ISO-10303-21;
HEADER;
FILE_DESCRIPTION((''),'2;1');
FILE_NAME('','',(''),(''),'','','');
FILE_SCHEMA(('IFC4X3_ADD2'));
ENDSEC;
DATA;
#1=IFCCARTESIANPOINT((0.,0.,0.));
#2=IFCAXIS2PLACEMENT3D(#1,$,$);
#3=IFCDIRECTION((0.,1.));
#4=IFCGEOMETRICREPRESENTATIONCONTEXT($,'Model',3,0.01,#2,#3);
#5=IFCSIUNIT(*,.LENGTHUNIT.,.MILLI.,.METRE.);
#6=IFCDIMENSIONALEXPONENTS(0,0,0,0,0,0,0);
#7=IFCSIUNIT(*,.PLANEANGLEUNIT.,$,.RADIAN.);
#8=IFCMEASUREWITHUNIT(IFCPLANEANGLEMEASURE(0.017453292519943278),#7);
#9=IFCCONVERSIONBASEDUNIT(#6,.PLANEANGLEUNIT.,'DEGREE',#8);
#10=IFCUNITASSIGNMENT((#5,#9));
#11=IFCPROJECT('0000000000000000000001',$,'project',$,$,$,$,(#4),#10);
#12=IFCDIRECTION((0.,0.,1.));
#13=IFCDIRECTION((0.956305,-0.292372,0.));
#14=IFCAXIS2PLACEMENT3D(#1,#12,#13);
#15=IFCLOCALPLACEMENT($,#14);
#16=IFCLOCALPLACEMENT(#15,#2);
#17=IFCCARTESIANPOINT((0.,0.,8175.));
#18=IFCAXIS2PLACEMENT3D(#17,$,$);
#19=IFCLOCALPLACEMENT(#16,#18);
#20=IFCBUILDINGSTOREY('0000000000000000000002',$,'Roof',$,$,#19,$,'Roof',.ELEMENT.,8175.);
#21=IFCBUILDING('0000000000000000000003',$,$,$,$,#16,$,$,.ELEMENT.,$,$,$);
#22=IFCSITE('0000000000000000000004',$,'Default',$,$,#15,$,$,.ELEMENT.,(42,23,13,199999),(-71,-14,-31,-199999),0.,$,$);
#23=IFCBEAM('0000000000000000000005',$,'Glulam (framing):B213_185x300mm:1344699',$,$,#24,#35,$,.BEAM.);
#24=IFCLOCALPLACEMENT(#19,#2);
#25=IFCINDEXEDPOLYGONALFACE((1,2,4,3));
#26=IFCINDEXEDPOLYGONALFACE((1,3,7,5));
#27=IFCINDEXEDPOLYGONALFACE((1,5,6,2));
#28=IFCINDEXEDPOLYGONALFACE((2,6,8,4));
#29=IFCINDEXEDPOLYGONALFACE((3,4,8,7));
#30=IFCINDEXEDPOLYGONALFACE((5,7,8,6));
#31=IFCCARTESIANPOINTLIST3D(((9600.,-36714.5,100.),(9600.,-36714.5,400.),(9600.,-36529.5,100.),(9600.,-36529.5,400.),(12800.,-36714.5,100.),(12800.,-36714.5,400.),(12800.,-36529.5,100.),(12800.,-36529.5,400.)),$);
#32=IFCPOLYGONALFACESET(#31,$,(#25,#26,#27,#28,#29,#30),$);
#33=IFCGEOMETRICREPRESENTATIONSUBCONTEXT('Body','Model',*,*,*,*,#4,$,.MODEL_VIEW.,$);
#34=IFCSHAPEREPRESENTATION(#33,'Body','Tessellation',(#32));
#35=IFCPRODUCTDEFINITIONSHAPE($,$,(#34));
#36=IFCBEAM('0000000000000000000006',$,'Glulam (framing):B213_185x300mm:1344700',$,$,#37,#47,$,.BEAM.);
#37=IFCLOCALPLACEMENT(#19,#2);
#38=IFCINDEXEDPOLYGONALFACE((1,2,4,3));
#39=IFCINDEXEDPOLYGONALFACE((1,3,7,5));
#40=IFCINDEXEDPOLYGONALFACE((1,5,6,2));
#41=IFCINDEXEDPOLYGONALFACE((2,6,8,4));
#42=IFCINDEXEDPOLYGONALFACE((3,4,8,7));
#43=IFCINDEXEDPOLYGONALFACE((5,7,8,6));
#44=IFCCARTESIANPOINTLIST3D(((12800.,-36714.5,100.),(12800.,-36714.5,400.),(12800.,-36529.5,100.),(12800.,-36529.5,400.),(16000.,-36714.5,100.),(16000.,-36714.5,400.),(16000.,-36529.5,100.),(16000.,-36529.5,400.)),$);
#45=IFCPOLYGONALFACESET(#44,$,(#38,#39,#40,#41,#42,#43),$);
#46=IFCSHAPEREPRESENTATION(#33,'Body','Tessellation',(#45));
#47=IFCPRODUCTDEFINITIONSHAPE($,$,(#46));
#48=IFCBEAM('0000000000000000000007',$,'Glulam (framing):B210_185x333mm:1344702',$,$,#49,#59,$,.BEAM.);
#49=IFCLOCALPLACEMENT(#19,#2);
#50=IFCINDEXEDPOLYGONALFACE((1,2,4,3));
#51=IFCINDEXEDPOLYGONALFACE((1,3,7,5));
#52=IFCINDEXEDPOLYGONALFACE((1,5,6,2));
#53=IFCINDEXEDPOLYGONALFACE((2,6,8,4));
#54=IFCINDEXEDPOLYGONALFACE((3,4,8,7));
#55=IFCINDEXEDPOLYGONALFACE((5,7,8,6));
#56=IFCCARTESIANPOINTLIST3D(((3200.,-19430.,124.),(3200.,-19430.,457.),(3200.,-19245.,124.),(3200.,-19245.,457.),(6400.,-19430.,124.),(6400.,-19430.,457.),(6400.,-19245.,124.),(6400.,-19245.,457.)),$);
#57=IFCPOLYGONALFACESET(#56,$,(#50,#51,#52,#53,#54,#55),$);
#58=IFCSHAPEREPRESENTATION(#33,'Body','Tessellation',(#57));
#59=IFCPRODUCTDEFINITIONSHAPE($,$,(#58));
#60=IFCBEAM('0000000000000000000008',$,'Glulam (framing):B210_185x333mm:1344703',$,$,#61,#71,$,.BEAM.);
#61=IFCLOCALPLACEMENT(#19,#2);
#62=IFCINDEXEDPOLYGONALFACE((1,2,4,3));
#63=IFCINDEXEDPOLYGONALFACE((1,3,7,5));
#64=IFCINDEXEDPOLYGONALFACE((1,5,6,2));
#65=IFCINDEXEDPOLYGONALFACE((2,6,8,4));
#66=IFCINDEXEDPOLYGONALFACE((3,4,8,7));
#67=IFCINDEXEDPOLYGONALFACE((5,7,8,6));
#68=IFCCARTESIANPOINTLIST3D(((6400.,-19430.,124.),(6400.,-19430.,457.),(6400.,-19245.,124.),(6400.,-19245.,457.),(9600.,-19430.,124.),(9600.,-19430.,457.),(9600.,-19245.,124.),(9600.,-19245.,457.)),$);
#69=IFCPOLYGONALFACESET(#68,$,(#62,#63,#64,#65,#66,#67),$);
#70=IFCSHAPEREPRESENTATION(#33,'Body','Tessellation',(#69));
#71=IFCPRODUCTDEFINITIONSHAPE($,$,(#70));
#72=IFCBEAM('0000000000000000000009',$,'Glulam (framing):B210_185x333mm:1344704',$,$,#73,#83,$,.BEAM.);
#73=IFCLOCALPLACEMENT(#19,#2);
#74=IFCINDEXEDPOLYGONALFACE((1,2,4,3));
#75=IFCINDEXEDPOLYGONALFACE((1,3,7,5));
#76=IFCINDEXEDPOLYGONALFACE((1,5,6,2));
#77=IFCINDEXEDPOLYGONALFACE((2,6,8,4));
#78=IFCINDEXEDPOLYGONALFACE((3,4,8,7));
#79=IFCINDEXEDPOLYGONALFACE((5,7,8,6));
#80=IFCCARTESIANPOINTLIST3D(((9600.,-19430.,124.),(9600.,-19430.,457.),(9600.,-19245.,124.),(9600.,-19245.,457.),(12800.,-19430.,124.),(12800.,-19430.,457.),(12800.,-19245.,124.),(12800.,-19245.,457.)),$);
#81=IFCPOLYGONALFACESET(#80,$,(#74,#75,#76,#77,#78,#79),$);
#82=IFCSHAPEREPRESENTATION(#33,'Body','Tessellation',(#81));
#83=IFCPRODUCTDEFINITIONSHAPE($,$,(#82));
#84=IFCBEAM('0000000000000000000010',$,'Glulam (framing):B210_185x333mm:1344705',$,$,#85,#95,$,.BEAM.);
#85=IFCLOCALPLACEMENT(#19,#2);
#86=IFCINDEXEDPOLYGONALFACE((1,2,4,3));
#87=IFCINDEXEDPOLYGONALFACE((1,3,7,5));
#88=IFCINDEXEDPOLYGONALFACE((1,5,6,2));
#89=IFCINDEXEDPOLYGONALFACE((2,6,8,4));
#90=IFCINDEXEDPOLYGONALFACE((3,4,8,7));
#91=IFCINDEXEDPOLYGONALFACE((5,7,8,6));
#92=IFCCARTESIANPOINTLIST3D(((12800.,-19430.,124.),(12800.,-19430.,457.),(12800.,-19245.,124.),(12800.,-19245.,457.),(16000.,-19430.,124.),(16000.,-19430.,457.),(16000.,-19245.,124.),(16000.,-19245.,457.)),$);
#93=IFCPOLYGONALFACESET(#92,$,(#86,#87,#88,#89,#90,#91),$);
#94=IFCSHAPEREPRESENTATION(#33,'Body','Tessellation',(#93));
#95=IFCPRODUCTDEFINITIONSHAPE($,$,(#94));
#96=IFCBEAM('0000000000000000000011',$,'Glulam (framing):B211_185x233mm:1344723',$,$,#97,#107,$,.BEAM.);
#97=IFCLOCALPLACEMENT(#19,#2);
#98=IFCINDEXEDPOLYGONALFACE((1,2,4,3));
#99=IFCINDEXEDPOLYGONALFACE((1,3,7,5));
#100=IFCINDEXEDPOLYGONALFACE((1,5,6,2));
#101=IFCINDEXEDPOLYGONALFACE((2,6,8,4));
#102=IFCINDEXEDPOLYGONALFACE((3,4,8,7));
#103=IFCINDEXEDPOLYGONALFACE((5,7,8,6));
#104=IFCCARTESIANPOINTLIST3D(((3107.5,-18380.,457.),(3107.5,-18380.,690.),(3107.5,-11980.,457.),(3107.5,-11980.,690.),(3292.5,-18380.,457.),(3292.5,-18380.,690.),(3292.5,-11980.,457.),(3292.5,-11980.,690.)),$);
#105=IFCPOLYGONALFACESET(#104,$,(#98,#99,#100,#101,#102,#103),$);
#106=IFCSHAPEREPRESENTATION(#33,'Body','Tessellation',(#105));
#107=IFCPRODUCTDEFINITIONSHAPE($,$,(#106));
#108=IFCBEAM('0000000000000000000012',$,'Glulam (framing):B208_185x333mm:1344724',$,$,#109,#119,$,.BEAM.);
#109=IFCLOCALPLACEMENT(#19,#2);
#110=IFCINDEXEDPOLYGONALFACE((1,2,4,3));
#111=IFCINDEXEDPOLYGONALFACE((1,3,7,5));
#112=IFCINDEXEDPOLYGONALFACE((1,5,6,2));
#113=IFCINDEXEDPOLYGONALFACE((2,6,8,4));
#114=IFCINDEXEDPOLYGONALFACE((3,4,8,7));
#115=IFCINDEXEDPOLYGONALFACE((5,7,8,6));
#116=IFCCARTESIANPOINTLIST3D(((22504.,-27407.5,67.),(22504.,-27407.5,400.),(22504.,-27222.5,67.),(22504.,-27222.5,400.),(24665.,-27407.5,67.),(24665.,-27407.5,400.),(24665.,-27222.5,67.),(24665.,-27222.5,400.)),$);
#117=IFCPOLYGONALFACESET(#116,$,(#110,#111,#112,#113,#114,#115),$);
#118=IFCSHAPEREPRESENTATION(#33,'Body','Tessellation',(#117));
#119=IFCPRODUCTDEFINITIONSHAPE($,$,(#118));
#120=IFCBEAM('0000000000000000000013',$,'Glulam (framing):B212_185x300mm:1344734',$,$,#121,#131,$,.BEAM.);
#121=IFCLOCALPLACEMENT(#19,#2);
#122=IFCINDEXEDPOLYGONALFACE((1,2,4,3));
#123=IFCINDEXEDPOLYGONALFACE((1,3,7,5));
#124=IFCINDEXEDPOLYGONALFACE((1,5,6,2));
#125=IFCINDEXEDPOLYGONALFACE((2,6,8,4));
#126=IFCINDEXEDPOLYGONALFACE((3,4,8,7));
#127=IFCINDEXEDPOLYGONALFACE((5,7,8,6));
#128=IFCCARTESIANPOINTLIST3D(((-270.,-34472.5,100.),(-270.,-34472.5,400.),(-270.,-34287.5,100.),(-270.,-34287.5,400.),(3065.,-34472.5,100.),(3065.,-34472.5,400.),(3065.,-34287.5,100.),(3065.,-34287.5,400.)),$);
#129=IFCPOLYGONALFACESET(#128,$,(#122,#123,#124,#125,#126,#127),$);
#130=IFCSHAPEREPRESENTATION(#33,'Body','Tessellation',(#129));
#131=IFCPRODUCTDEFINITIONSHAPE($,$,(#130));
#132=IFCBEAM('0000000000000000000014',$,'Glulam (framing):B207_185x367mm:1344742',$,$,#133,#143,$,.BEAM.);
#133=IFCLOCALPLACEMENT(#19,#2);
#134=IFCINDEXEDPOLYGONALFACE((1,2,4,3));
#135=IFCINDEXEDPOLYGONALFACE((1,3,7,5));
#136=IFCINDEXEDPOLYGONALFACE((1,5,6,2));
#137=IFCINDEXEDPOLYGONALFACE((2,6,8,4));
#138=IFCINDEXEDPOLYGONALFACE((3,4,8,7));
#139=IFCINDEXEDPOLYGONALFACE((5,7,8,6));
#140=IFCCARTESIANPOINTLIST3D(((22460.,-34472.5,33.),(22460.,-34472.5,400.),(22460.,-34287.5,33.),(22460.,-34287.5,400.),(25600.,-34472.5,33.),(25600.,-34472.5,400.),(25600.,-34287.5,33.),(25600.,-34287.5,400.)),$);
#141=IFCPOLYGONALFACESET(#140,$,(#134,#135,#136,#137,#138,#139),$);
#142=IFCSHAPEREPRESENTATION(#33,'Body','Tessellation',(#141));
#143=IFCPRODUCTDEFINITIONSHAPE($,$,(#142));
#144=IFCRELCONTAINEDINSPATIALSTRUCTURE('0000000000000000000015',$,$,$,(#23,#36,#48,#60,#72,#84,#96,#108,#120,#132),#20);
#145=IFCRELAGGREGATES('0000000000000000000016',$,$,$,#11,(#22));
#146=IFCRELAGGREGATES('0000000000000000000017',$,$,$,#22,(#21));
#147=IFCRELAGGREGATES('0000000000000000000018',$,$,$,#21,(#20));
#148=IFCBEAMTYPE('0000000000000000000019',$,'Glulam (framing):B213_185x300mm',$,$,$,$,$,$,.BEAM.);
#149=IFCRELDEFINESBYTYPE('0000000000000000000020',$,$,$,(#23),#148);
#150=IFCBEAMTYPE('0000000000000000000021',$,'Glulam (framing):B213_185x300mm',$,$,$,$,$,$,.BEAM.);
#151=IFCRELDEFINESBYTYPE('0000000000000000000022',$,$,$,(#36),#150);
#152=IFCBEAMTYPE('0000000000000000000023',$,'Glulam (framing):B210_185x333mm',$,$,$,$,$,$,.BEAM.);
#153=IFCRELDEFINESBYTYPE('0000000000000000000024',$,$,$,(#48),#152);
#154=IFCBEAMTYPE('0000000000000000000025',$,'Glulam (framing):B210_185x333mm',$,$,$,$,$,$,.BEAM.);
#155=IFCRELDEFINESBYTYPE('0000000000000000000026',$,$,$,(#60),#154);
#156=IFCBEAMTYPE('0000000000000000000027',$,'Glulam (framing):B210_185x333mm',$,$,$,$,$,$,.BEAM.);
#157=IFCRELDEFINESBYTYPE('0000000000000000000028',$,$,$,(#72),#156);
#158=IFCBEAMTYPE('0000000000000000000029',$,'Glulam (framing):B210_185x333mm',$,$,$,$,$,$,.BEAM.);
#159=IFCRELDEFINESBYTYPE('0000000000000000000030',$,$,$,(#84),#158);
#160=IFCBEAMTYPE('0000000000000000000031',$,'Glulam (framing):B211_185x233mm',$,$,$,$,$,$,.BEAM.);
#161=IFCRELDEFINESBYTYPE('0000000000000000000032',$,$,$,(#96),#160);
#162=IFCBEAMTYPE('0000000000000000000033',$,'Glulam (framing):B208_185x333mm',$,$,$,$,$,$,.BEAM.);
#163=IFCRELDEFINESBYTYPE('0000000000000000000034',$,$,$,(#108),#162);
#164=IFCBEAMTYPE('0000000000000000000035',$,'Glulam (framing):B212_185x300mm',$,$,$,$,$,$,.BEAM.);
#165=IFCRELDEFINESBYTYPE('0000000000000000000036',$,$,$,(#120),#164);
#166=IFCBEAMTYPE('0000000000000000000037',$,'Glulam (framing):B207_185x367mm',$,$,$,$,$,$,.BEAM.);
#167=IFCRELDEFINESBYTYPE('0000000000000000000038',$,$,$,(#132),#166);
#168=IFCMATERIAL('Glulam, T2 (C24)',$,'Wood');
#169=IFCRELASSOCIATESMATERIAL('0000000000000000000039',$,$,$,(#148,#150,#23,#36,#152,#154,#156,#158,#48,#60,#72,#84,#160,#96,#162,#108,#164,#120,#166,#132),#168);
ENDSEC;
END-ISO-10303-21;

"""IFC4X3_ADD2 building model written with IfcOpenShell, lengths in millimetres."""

from ifc_helpers import new_model, entity, si_unit, converted_unit, direction, frame, origin, origin_2d_with_axis, place, context, subcontext, project, spatial, rectangle, extrude, source, transform, mapped, material, material_profile, profile_set, profile_usage, type_object, type_shapes, element, save


model = new_model("IFC4X3_ADD2")

# Units and contexts
model_context = context("Model", 3, precision=0.01, world=origin(), true_north=direction((0.0, 1.0)))
body_context = subcontext(model_context, "Body", "Model", "MODEL_VIEW")
ifc_project = project(units=[si_unit("LENGTHUNIT", "METRE", prefix="MILLI"), converted_unit("PLANEANGLEUNIT", "DEGREE", entity("IfcPlaneAngleMeasure", 0.017453292519943278), si_unit("PLANEANGLEUNIT", "RADIAN"), dimensions=[0, 0, 0, 0, 0, 0, 0])], contexts=[model_context])

# Site, building, storey
site_placement = place(None, frame((0.0, 0.0, 0.0), z_axis=(0.0, 0.0, 1.0), x_axis=(0.956305, -0.292372, 0.0)))
site = spatial("IfcSite", under=ifc_project, at=site_placement, Name="Default", CompositionType="ELEMENT", RefLatitude=(42, 23, 13, 199999), RefLongitude=(-71, -14, -31, -199999), RefElevation=0.0)
building_placement = place(site_placement, origin())
building = spatial("IfcBuilding", under=site, at=building_placement, CompositionType="ELEMENT")
storey_placement = place(building_placement, frame((0.0, 0.0, 8175.0)))
storey = spatial("IfcBuildingStorey", under=building, at=storey_placement, Name="Roof", LongName="Roof", CompositionType="ELEMENT", Elevation=8175.0)

# Beams
ifc_material = material(Name="Glulam, T2 (C24)", Category="Wood")
ifc_material_profile_1 = material_profile(ifc_material, rectangle(XDim=3200.0, YDim=185.0, at=origin_2d_with_axis()), Name="B213_185x300mm")
ifc_profile_set_1 = profile_set([ifc_material_profile_1], Name="B213_185x300mm")
ifc_profile_usage_1 = profile_usage(ifc_profile_set_1, cardinal=8)
beam_type_1 = type_object("IfcBeamType", Name="Glulam (framing):B213_185x300mm", PredefinedType="BEAM", material=ifc_profile_set_1)
shared_shape_1 = source(origin(), body_context, "Body", "SweptSolid", [
    extrude(rectangle(XDim=3200.0, YDim=185.0, at=origin_2d_with_axis()), frame((0.0, 0.0, -150.0), z_axis=(0.0, 0.0, 1.0), x_axis=(-1.0, 0.0, 0.0)), (0.0, 0.0, 1.0), 300.0),
])
type_shapes(beam_type_1, [shared_shape_1])
beam_1_placement = place(storey_placement, frame((11200.0, -36622.0, 250.0), z_axis=(0.0, 0.0, 1.0), x_axis=(-1.0, 0.0, 0.0)))
element("IfcBeam", 1, at=beam_1_placement, inside=storey, type_object=beam_type_1, material=ifc_profile_usage_1, Name="Glulam (framing):B213_185x300mm:1344699", PredefinedType="BEAM", context=body_context, shape_type="MappedRepresentation", body=[
    mapped(shared_shape_1, transform((0.0, 0.0, 0.0), scale=1.0)),
])
beam_type_2 = type_object("IfcBeamType", Name="Glulam (framing):B213_185x300mm", PredefinedType="BEAM", material=ifc_profile_set_1)
shared_shape_2 = source(origin(), body_context, "Body", "SweptSolid", [
    extrude(rectangle(XDim=3200.0, YDim=185.0, at=origin_2d_with_axis()), frame((0.0, 0.0, -150.0), z_axis=(0.0, 0.0, 1.0), x_axis=(-1.0, 0.0, 0.0)), (0.0, 0.0, 1.0), 300.0),
])
type_shapes(beam_type_2, [shared_shape_2])
beam_2_placement = place(storey_placement, frame((14400.0, -36622.0, 250.0), z_axis=(0.0, 0.0, 1.0), x_axis=(-1.0, 0.0, 0.0)))
element("IfcBeam", 2, at=beam_2_placement, inside=storey, type_object=beam_type_2, material=ifc_profile_usage_1, Name="Glulam (framing):B213_185x300mm:1344700", PredefinedType="BEAM", context=body_context, shape_type="MappedRepresentation", body=[
    mapped(shared_shape_2, transform((0.0, 0.0, 0.0), scale=1.0)),
])
ifc_material_profile_2 = material_profile(ifc_material, rectangle(XDim=185.0, YDim=3200.0, at=origin_2d_with_axis()), Name="B210_185x333mm")
ifc_profile_set_2 = profile_set([ifc_material_profile_2], Name="B210_185x333mm")
ifc_profile_usage_2 = profile_usage(ifc_profile_set_2, cardinal=8)
beam_type_3 = type_object("IfcBeamType", Name="Glulam (framing):B210_185x333mm", PredefinedType="BEAM", material=ifc_profile_set_2)
shared_shape_3 = source(origin(), body_context, "Body", "SweptSolid", [
    extrude(rectangle(XDim=185.0, YDim=3200.0, at=origin_2d_with_axis()), frame((0.0, 0.0, -166.5), z_axis=(0.0, 0.0, 1.0), x_axis=(0.0, 1.0, 0.0)), (0.0, 0.0, 1.0), 333.0),
])
type_shapes(beam_type_3, [shared_shape_3])
beam_3_placement = place(storey_placement, frame((4800.0, -19337.5, 290.5), z_axis=(0.0, 0.0, 1.0), x_axis=(-1.0, 0.0, 0.0)))
element("IfcBeam", 3, at=beam_3_placement, inside=storey, type_object=beam_type_3, material=ifc_profile_usage_2, Name="Glulam (framing):B210_185x333mm:1344702", PredefinedType="BEAM", context=body_context, shape_type="MappedRepresentation", body=[
    mapped(shared_shape_3, transform((0.0, 0.0, 0.0), scale=1.0)),
])
beam_type_4 = type_object("IfcBeamType", Name="Glulam (framing):B210_185x333mm", PredefinedType="BEAM", material=ifc_profile_set_2)
shared_shape_4 = source(origin(), body_context, "Body", "SweptSolid", [
    extrude(rectangle(XDim=185.0, YDim=3200.0, at=origin_2d_with_axis()), frame((0.0, 0.0, -166.5), z_axis=(0.0, 0.0, 1.0), x_axis=(0.0, 1.0, 0.0)), (0.0, 0.0, 1.0), 333.0),
])
type_shapes(beam_type_4, [shared_shape_4])
beam_4_placement = place(storey_placement, frame((8000.0, -19337.5, 290.5), z_axis=(0.0, 0.0, 1.0), x_axis=(-1.0, 0.0, 0.0)))
element("IfcBeam", 4, at=beam_4_placement, inside=storey, type_object=beam_type_4, material=ifc_profile_usage_2, Name="Glulam (framing):B210_185x333mm:1344703", PredefinedType="BEAM", context=body_context, shape_type="MappedRepresentation", body=[
    mapped(shared_shape_4, transform((0.0, 0.0, 0.0), scale=1.0)),
])
beam_type_5 = type_object("IfcBeamType", Name="Glulam (framing):B210_185x333mm", PredefinedType="BEAM", material=ifc_profile_set_2)
shared_shape_5 = source(origin(), body_context, "Body", "SweptSolid", [
    extrude(rectangle(XDim=185.0, YDim=3200.0, at=origin_2d_with_axis()), frame((0.0, 0.0, -166.5), z_axis=(0.0, 0.0, 1.0), x_axis=(0.0, 1.0, 0.0)), (0.0, 0.0, 1.0), 333.0),
])
type_shapes(beam_type_5, [shared_shape_5])
beam_5_placement = place(storey_placement, frame((11200.0, -19337.5, 290.5), z_axis=(0.0, 0.0, 1.0), x_axis=(-1.0, 0.0, 0.0)))
element("IfcBeam", 5, at=beam_5_placement, inside=storey, type_object=beam_type_5, material=ifc_profile_usage_2, Name="Glulam (framing):B210_185x333mm:1344704", PredefinedType="BEAM", context=body_context, shape_type="MappedRepresentation", body=[
    mapped(shared_shape_5, transform((0.0, 0.0, 0.0), scale=1.0)),
])
beam_type_6 = type_object("IfcBeamType", Name="Glulam (framing):B210_185x333mm", PredefinedType="BEAM", material=ifc_profile_set_2)
shared_shape_6 = source(origin(), body_context, "Body", "SweptSolid", [
    extrude(rectangle(XDim=185.0, YDim=3200.0, at=origin_2d_with_axis()), frame((0.0, 0.0, -166.5), z_axis=(0.0, 0.0, 1.0), x_axis=(0.0, 1.0, 0.0)), (0.0, 0.0, 1.0), 333.0),
])
type_shapes(beam_type_6, [shared_shape_6])
beam_6_placement = place(storey_placement, frame((14400.0, -19337.5, 290.5), z_axis=(0.0, 0.0, 1.0), x_axis=(-1.0, 0.0, 0.0)))
element("IfcBeam", 6, at=beam_6_placement, inside=storey, type_object=beam_type_6, material=ifc_profile_usage_2, Name="Glulam (framing):B210_185x333mm:1344705", PredefinedType="BEAM", context=body_context, shape_type="MappedRepresentation", body=[
    mapped(shared_shape_6, transform((0.0, 0.0, 0.0), scale=1.0)),
])
ifc_material_profile_3 = material_profile(ifc_material, rectangle(XDim=3200.0, YDim=185.0, at=origin_2d_with_axis()), Name="B211_185x233mm")
ifc_profile_set_3 = profile_set([ifc_material_profile_3], Name="B211_185x233mm")
ifc_profile_usage_3 = profile_usage(ifc_profile_set_3, cardinal=8)
beam_type_7 = type_object("IfcBeamType", Name="Glulam (framing):B211_185x233mm", PredefinedType="BEAM", material=ifc_profile_set_3)
shared_shape_7 = source(origin(), body_context, "Body", "SweptSolid", [
    extrude(rectangle(XDim=6400.0, YDim=185.0, at=origin_2d_with_axis()), frame((-1600.0, 0.0, -116.5), z_axis=(0.0, 0.0, 1.0), x_axis=(-1.0, 0.0, 0.0)), (0.0, 0.0, 1.0), 233.0),
])
type_shapes(beam_type_7, [shared_shape_7])
beam_7_placement = place(storey_placement, frame((3200.0, -16780.0, 573.5), z_axis=(0.0, 0.0, 1.0), x_axis=(0.0, -1.0, 0.0)))
element("IfcBeam", 7, at=beam_7_placement, inside=storey, type_object=beam_type_7, material=ifc_profile_usage_3, Name="Glulam (framing):B211_185x233mm:1344723", PredefinedType="BEAM", context=body_context, shape_type="MappedRepresentation", body=[
    mapped(shared_shape_7, transform((0.0, 0.0, 0.0), scale=1.0)),
])
ifc_material_profile_4 = material_profile(ifc_material, rectangle(XDim=2161.0, YDim=185.0, at=origin_2d_with_axis()), Name="B208_185x333mm")
ifc_profile_set_4 = profile_set([ifc_material_profile_4], Name="B208_185x333mm")
ifc_profile_usage_4 = profile_usage(ifc_profile_set_4, cardinal=8)
beam_type_8 = type_object("IfcBeamType", Name="Glulam (framing):B208_185x333mm", PredefinedType="BEAM", material=ifc_profile_set_4)
shared_shape_8 = source(origin(), body_context, "Body", "SweptSolid", [
    extrude(rectangle(XDim=2161.0, YDim=185.0, at=origin_2d_with_axis()), frame((-505.4, 0.0, -166.5), z_axis=(0.0, 0.0, 1.0), x_axis=(-1.0, 0.0, 0.0)), (0.0, 0.0, 1.0), 333.0),
])
type_shapes(beam_type_8, [shared_shape_8])
beam_8_placement = place(storey_placement, frame((24089.9, -27315.0, 233.5)))
element("IfcBeam", 8, at=beam_8_placement, inside=storey, type_object=beam_type_8, material=ifc_profile_usage_4, Name="Glulam (framing):B208_185x333mm:1344724", PredefinedType="BEAM", context=body_context, shape_type="MappedRepresentation", body=[
    mapped(shared_shape_8, transform((0.0, 0.0, 0.0), scale=1.0)),
])
ifc_material_profile_5 = material_profile(ifc_material, rectangle(XDim=3335.0, YDim=185.0, at=origin_2d_with_axis()), Name="B212_185x300mm")
ifc_profile_set_5 = profile_set([ifc_material_profile_5], Name="B212_185x300mm")
ifc_profile_usage_5 = profile_usage(ifc_profile_set_5, cardinal=8)
beam_type_9 = type_object("IfcBeamType", Name="Glulam (framing):B212_185x300mm", PredefinedType="BEAM", material=ifc_profile_set_5)
shared_shape_9 = source(origin(), body_context, "Body", "SweptSolid", [
    extrude(rectangle(XDim=3335.0, YDim=185.0, at=origin_2d_with_axis()), frame((235.9, 0.0, -150.0), z_axis=(0.0, 0.0, 1.0), x_axis=(-1.0, 0.0, 0.0)), (0.0, 0.0, 1.0), 300.0),
])
type_shapes(beam_type_9, [shared_shape_9])
beam_9_placement = place(storey_placement, frame((1633.4, -34380.0, 250.0), z_axis=(0.0, 0.0, 1.0), x_axis=(-1.0, 0.0, 0.0)))
element("IfcBeam", 9, at=beam_9_placement, inside=storey, type_object=beam_type_9, material=ifc_profile_usage_5, Name="Glulam (framing):B212_185x300mm:1344734", PredefinedType="BEAM", context=body_context, shape_type="MappedRepresentation", body=[
    mapped(shared_shape_9, transform((0.0, 0.0, 0.0), scale=1.0)),
])
ifc_material_profile_6 = material_profile(ifc_material, rectangle(XDim=3140.0, YDim=185.0, at=origin_2d_with_axis()), Name="B207_185x367mm")
ifc_profile_set_6 = profile_set([ifc_material_profile_6], Name="B207_185x367mm")
ifc_profile_usage_6 = profile_usage(ifc_profile_set_6, cardinal=8)
beam_type_10 = type_object("IfcBeamType", Name="Glulam (framing):B207_185x367mm", PredefinedType="BEAM", material=ifc_profile_set_6)
shared_shape_10 = source(origin(), body_context, "Body", "SweptSolid", [
    extrude(rectangle(XDim=3140.0, YDim=185.0, at=origin_2d_with_axis()), frame((-61.3, 0.0, -183.5), z_axis=(0.0, 0.0, 1.0), x_axis=(-1.0, 0.0, 0.0)), (0.0, 0.0, 1.0), 367.0),
])
type_shapes(beam_type_10, [shared_shape_10])
beam_10_placement = place(storey_placement, frame((24091.3, -34380.0, 216.5)))
element("IfcBeam", 10, at=beam_10_placement, inside=storey, type_object=beam_type_10, material=ifc_profile_usage_6, Name="Glulam (framing):B207_185x367mm:1344742", PredefinedType="BEAM", context=body_context, shape_type="MappedRepresentation", body=[
    mapped(shared_shape_10, transform((0.0, 0.0, 0.0), scale=1.0)),
])

save(model, "model.ifc")
